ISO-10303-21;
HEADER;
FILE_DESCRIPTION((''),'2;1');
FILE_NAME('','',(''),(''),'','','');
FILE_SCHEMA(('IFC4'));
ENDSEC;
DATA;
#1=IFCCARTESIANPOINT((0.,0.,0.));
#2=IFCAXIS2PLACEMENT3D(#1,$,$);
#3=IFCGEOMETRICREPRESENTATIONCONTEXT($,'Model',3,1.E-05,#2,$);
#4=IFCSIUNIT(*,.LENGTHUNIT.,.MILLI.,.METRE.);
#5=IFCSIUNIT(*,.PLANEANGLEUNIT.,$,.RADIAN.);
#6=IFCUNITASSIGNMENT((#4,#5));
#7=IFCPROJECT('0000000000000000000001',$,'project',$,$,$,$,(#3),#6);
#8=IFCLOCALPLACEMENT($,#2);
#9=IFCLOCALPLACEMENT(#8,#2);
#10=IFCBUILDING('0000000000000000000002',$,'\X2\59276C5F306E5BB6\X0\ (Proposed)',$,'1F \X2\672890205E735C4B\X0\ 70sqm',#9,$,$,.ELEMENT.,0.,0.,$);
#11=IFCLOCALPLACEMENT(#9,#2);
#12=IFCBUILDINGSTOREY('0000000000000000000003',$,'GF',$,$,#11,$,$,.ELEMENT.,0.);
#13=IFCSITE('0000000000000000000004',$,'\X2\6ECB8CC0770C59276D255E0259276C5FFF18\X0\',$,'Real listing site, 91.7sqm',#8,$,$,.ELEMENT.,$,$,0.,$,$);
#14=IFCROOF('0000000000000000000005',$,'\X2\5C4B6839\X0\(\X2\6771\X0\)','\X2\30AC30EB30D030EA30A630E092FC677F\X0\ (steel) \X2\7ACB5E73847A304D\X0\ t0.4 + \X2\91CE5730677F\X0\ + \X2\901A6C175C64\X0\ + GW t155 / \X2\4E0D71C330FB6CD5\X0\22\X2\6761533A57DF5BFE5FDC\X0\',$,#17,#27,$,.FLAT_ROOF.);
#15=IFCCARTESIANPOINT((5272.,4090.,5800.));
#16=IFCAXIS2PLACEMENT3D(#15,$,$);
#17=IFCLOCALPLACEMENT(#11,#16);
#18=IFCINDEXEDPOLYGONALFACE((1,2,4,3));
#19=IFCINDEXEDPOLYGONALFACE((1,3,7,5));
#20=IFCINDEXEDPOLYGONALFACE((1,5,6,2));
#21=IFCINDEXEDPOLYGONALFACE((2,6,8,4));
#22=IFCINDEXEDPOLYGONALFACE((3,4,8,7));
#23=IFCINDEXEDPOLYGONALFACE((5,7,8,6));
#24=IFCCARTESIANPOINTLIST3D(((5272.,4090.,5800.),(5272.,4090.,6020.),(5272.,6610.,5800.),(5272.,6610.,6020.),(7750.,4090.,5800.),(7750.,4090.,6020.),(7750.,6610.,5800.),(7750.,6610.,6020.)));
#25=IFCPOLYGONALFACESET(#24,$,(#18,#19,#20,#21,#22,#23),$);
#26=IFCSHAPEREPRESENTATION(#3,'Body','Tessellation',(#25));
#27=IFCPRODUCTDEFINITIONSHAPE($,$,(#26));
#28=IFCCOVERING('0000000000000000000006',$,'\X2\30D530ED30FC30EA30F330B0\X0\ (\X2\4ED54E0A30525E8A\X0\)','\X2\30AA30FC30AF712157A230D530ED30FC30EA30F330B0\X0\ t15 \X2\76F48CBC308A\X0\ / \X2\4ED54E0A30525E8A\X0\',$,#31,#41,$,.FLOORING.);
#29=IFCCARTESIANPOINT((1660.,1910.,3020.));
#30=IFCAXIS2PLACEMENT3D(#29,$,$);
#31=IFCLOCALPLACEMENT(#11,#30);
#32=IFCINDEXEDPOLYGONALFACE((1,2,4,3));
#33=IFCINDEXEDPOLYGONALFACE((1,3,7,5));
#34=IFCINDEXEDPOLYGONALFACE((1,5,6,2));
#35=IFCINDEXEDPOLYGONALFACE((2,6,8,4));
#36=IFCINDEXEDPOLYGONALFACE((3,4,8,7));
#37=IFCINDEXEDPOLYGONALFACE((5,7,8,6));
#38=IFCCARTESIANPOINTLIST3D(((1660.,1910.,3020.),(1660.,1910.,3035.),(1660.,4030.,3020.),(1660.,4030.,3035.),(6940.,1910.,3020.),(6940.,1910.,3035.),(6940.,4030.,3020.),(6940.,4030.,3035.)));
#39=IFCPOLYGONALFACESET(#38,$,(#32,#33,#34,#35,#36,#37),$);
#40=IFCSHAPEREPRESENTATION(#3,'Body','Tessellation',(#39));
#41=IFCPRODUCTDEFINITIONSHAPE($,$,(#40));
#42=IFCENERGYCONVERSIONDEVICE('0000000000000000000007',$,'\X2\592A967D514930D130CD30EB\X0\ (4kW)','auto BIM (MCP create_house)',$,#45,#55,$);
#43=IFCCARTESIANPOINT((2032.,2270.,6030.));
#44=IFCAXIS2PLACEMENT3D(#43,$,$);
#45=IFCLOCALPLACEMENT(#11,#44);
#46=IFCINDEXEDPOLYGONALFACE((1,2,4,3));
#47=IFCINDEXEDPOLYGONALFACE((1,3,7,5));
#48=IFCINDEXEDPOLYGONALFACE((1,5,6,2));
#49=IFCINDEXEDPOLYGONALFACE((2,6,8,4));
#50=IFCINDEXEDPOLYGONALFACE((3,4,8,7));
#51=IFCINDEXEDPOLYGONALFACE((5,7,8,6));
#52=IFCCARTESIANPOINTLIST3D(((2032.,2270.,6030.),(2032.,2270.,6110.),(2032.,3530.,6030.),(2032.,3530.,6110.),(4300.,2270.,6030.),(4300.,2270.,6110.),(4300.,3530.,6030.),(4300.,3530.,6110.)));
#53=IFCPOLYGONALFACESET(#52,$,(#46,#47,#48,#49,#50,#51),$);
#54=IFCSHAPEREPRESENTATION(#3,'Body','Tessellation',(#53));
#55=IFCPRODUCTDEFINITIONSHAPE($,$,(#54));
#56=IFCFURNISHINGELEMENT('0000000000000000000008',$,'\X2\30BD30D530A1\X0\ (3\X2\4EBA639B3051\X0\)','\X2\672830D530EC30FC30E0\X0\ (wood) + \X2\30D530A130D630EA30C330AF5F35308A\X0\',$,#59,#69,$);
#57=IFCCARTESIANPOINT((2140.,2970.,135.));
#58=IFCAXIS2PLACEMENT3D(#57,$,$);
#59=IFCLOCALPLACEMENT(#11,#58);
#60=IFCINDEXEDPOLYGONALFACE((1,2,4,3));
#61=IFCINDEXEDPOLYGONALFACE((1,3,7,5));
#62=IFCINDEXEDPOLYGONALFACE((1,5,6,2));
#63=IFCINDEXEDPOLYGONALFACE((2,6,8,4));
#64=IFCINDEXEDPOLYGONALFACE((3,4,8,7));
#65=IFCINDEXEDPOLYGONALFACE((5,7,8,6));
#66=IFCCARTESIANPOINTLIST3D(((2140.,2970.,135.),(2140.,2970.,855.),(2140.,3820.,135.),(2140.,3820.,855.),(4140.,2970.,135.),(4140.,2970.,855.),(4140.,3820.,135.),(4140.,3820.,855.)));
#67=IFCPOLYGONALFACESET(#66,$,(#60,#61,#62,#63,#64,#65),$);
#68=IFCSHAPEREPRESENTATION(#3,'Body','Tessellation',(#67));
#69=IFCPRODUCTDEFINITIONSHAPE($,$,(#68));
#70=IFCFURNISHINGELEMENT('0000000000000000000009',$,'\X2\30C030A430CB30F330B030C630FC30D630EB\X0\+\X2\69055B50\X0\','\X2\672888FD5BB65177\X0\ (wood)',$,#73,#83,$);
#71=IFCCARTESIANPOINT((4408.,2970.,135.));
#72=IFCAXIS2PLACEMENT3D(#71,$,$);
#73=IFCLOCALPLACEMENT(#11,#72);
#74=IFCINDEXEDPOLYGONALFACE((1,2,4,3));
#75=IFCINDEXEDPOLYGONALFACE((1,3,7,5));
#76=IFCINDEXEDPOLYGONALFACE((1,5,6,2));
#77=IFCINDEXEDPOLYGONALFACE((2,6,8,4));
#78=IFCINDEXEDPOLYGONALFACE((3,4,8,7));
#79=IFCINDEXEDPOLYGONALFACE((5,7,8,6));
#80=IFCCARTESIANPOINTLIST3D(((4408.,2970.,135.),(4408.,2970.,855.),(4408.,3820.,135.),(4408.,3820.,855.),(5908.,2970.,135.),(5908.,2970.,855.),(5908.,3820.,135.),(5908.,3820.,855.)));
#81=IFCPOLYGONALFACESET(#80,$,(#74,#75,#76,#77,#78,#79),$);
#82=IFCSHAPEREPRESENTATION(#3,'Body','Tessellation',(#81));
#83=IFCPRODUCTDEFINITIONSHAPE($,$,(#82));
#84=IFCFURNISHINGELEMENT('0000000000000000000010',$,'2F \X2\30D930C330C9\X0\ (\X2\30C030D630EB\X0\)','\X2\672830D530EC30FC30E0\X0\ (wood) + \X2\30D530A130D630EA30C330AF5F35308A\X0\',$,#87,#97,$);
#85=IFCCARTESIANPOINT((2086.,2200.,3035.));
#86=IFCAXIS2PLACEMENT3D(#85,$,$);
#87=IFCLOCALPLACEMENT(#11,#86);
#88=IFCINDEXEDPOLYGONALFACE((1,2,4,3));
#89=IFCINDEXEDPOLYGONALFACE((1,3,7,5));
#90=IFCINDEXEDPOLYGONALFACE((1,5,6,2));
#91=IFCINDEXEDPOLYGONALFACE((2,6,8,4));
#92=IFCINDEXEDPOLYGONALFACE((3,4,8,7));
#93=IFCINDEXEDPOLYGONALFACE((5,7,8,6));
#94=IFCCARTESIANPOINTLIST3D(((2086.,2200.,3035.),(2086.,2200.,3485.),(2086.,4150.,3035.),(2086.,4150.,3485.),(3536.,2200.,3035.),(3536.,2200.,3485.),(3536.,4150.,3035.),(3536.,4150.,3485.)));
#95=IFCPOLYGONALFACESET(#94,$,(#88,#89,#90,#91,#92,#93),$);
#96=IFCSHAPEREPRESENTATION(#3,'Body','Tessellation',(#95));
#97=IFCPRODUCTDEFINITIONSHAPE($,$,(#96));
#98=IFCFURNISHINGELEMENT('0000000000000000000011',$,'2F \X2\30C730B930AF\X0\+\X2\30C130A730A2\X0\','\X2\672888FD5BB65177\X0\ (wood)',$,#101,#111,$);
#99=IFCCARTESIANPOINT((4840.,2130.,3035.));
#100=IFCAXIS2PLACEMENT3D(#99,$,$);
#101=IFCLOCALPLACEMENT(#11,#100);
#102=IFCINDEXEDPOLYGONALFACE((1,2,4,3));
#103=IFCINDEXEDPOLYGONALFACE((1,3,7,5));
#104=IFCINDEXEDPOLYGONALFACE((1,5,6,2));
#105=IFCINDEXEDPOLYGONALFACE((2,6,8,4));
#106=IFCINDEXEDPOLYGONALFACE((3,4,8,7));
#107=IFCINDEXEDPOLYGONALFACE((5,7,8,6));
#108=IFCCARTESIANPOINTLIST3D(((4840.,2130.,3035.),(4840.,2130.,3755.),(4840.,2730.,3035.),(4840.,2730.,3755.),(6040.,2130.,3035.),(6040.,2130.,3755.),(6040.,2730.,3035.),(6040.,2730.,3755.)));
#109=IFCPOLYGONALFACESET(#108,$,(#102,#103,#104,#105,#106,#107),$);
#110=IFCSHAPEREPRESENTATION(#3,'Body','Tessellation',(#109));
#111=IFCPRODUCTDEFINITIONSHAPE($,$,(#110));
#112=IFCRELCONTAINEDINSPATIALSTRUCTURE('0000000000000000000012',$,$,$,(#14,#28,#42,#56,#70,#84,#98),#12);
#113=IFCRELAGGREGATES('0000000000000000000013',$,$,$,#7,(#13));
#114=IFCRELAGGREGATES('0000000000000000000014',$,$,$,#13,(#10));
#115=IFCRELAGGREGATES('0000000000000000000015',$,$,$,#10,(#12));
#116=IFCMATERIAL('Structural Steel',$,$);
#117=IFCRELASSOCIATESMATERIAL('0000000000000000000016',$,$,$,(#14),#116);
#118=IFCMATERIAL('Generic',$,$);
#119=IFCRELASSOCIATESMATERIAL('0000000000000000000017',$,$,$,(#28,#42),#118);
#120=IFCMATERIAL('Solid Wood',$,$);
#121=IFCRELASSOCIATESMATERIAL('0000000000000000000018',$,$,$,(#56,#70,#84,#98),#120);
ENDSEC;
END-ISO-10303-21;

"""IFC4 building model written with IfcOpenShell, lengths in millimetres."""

from ifc_helpers import new_model, si_unit, frame, frame_2d, origin, place, context, project, spatial, rectangle, extrude, material, element, save


model = new_model("IFC4")

# Units and contexts
model_context = context("Model", 3, precision=1e-05, world=origin())
ifc_project = project(units=[si_unit("LENGTHUNIT", "METRE", prefix="MILLI"), si_unit("PLANEANGLEUNIT", "RADIAN")], contexts=[model_context])

# Site, building, storey
site_placement = place(None, origin())
site = spatial("IfcSite", under=ifc_project, at=site_placement, Name="滋賀県大津市大江８", ObjectType="Real listing site, 91.7sqm", CompositionType="ELEMENT", RefElevation=0.0)
building_placement = place(site_placement, origin())
building = spatial("IfcBuilding", under=site, at=building_placement, Name="大江の家 (Proposed)", ObjectType="1F 木造平屋 70sqm", CompositionType="ELEMENT", ElevationOfRefHeight=0.0, ElevationOfTerrain=0.0)
storey_placement = place(building_placement, origin())
storey = spatial("IfcBuildingStorey", under=building, at=storey_placement, Name="GF", CompositionType="ELEMENT", Elevation=0.0)

# Shared definitions
ifc_material_1 = material(Name="Solid Wood")

# Roof
ifc_material_2 = material(Name="Structural Steel")
roof_1_placement = place(storey_placement, frame((5272.0, 4090.0, 5800.0)))
element("IfcRoof", 1, at=roof_1_placement, inside=storey, material=ifc_material_2, Name="屋根(東)", Description="ガルバリウム鋼板 (steel) 立平葺き t0.4 + 野地板 + 通気層 + GW t155 / 不燃・法22条区域対応", PredefinedType="FLAT_ROOF", context=model_context, shape_type="SweptSolid", body=[
    extrude(rectangle(XDim=2478.0, YDim=2520.0, at=frame_2d((1239.0, 1260.0))), frame((5272.0, 4090.0, 5800.0)), (0.0, 0.0, 1.0), 220.0),
])

# Covering
ifc_material_3 = material(Name="Generic")
covering_placement = place(storey_placement, frame((1660.0, 1910.0, 3020.0)))
element("IfcCovering", 2, at=covering_placement, inside=storey, material=ifc_material_3, Name="フローリング (仕上げ床)", Description="オーク無垢フローリング t15 直貼り / 仕上げ床", PredefinedType="FLOORING", context=model_context, shape_type="SweptSolid", body=[
    extrude(rectangle(XDim=5280.0, YDim=2120.0, at=frame_2d((2640.0, 1060.0))), frame((1660.0, 1910.0, 3020.0)), (0.0, 0.0, 1.0), 15.0),
])

# Energy conversion device
energy_conversion_device_placement = place(storey_placement, frame((2032.0, 2270.0, 6030.0)))
element("IfcEnergyConversionDevice", 3, at=energy_conversion_device_placement, inside=storey, material=ifc_material_3, Name="太陽光パネル (4kW)", Description="auto BIM (MCP create_house)", context=model_context, shape_type="SweptSolid", body=[
    extrude(rectangle(XDim=2268.0, YDim=1260.0, at=frame_2d((1134.0, 630.0))), frame((2032.0, 2270.0, 6030.0)), (0.0, 0.0, 1.0), 80.0),
])

# Furnishing elements
furnishing_1_placement = place(storey_placement, frame((2140.0, 2970.0, 135.0)))
element("IfcFurnishingElement", 4, at=furnishing_1_placement, inside=storey, material=ifc_material_1, Name="ソファ (3人掛け)", Description="木フレーム (wood) + ファブリック張り", context=model_context, shape_type="SweptSolid", body=[
    extrude(rectangle(XDim=2000.0, YDim=850.0, at=frame_2d((1000.0, 425.0))), frame((2140.0, 2970.0, 135.0)), (0.0, 0.0, 1.0), 720.0),
])
furnishing_2_placement = place(storey_placement, frame((4408.0, 2970.0, 135.0)))
element("IfcFurnishingElement", 5, at=furnishing_2_placement, inside=storey, material=ifc_material_1, Name="ダイニングテーブル+椅子", Description="木製家具 (wood)", context=model_context, shape_type="SweptSolid", body=[
    extrude(rectangle(XDim=1500.0, YDim=850.0, at=frame_2d((750.0, 425.0))), frame((4408.0, 2970.0, 135.0)), (0.0, 0.0, 1.0), 720.0),
])
furnishing_3_placement = place(storey_placement, frame((2086.0, 2200.0, 3035.0)))
element("IfcFurnishingElement", 6, at=furnishing_3_placement, inside=storey, material=ifc_material_1, Name="2F ベッド (ダブル)", Description="木フレーム (wood) + ファブリック張り", context=model_context, shape_type="SweptSolid", body=[
    extrude(rectangle(XDim=1450.0, YDim=1950.0, at=frame_2d((725.0, 975.0))), frame((2086.0, 2200.0, 3035.0)), (0.0, 0.0, 1.0), 450.0),
])
furnishing_4_placement = place(storey_placement, frame((4840.0, 2130.0, 3035.0)))
element("IfcFurnishingElement", 7, at=furnishing_4_placement, inside=storey, material=ifc_material_1, Name="2F デスク+チェア", Description="木製家具 (wood)", context=model_context, shape_type="SweptSolid", body=[
    extrude(rectangle(XDim=1200.0, YDim=600.0, at=frame_2d((600.0, 300.0))), frame((4840.0, 2130.0, 3035.0)), (0.0, 0.0, 1.0), 720.0),
])

save(model, "model.ifc")
